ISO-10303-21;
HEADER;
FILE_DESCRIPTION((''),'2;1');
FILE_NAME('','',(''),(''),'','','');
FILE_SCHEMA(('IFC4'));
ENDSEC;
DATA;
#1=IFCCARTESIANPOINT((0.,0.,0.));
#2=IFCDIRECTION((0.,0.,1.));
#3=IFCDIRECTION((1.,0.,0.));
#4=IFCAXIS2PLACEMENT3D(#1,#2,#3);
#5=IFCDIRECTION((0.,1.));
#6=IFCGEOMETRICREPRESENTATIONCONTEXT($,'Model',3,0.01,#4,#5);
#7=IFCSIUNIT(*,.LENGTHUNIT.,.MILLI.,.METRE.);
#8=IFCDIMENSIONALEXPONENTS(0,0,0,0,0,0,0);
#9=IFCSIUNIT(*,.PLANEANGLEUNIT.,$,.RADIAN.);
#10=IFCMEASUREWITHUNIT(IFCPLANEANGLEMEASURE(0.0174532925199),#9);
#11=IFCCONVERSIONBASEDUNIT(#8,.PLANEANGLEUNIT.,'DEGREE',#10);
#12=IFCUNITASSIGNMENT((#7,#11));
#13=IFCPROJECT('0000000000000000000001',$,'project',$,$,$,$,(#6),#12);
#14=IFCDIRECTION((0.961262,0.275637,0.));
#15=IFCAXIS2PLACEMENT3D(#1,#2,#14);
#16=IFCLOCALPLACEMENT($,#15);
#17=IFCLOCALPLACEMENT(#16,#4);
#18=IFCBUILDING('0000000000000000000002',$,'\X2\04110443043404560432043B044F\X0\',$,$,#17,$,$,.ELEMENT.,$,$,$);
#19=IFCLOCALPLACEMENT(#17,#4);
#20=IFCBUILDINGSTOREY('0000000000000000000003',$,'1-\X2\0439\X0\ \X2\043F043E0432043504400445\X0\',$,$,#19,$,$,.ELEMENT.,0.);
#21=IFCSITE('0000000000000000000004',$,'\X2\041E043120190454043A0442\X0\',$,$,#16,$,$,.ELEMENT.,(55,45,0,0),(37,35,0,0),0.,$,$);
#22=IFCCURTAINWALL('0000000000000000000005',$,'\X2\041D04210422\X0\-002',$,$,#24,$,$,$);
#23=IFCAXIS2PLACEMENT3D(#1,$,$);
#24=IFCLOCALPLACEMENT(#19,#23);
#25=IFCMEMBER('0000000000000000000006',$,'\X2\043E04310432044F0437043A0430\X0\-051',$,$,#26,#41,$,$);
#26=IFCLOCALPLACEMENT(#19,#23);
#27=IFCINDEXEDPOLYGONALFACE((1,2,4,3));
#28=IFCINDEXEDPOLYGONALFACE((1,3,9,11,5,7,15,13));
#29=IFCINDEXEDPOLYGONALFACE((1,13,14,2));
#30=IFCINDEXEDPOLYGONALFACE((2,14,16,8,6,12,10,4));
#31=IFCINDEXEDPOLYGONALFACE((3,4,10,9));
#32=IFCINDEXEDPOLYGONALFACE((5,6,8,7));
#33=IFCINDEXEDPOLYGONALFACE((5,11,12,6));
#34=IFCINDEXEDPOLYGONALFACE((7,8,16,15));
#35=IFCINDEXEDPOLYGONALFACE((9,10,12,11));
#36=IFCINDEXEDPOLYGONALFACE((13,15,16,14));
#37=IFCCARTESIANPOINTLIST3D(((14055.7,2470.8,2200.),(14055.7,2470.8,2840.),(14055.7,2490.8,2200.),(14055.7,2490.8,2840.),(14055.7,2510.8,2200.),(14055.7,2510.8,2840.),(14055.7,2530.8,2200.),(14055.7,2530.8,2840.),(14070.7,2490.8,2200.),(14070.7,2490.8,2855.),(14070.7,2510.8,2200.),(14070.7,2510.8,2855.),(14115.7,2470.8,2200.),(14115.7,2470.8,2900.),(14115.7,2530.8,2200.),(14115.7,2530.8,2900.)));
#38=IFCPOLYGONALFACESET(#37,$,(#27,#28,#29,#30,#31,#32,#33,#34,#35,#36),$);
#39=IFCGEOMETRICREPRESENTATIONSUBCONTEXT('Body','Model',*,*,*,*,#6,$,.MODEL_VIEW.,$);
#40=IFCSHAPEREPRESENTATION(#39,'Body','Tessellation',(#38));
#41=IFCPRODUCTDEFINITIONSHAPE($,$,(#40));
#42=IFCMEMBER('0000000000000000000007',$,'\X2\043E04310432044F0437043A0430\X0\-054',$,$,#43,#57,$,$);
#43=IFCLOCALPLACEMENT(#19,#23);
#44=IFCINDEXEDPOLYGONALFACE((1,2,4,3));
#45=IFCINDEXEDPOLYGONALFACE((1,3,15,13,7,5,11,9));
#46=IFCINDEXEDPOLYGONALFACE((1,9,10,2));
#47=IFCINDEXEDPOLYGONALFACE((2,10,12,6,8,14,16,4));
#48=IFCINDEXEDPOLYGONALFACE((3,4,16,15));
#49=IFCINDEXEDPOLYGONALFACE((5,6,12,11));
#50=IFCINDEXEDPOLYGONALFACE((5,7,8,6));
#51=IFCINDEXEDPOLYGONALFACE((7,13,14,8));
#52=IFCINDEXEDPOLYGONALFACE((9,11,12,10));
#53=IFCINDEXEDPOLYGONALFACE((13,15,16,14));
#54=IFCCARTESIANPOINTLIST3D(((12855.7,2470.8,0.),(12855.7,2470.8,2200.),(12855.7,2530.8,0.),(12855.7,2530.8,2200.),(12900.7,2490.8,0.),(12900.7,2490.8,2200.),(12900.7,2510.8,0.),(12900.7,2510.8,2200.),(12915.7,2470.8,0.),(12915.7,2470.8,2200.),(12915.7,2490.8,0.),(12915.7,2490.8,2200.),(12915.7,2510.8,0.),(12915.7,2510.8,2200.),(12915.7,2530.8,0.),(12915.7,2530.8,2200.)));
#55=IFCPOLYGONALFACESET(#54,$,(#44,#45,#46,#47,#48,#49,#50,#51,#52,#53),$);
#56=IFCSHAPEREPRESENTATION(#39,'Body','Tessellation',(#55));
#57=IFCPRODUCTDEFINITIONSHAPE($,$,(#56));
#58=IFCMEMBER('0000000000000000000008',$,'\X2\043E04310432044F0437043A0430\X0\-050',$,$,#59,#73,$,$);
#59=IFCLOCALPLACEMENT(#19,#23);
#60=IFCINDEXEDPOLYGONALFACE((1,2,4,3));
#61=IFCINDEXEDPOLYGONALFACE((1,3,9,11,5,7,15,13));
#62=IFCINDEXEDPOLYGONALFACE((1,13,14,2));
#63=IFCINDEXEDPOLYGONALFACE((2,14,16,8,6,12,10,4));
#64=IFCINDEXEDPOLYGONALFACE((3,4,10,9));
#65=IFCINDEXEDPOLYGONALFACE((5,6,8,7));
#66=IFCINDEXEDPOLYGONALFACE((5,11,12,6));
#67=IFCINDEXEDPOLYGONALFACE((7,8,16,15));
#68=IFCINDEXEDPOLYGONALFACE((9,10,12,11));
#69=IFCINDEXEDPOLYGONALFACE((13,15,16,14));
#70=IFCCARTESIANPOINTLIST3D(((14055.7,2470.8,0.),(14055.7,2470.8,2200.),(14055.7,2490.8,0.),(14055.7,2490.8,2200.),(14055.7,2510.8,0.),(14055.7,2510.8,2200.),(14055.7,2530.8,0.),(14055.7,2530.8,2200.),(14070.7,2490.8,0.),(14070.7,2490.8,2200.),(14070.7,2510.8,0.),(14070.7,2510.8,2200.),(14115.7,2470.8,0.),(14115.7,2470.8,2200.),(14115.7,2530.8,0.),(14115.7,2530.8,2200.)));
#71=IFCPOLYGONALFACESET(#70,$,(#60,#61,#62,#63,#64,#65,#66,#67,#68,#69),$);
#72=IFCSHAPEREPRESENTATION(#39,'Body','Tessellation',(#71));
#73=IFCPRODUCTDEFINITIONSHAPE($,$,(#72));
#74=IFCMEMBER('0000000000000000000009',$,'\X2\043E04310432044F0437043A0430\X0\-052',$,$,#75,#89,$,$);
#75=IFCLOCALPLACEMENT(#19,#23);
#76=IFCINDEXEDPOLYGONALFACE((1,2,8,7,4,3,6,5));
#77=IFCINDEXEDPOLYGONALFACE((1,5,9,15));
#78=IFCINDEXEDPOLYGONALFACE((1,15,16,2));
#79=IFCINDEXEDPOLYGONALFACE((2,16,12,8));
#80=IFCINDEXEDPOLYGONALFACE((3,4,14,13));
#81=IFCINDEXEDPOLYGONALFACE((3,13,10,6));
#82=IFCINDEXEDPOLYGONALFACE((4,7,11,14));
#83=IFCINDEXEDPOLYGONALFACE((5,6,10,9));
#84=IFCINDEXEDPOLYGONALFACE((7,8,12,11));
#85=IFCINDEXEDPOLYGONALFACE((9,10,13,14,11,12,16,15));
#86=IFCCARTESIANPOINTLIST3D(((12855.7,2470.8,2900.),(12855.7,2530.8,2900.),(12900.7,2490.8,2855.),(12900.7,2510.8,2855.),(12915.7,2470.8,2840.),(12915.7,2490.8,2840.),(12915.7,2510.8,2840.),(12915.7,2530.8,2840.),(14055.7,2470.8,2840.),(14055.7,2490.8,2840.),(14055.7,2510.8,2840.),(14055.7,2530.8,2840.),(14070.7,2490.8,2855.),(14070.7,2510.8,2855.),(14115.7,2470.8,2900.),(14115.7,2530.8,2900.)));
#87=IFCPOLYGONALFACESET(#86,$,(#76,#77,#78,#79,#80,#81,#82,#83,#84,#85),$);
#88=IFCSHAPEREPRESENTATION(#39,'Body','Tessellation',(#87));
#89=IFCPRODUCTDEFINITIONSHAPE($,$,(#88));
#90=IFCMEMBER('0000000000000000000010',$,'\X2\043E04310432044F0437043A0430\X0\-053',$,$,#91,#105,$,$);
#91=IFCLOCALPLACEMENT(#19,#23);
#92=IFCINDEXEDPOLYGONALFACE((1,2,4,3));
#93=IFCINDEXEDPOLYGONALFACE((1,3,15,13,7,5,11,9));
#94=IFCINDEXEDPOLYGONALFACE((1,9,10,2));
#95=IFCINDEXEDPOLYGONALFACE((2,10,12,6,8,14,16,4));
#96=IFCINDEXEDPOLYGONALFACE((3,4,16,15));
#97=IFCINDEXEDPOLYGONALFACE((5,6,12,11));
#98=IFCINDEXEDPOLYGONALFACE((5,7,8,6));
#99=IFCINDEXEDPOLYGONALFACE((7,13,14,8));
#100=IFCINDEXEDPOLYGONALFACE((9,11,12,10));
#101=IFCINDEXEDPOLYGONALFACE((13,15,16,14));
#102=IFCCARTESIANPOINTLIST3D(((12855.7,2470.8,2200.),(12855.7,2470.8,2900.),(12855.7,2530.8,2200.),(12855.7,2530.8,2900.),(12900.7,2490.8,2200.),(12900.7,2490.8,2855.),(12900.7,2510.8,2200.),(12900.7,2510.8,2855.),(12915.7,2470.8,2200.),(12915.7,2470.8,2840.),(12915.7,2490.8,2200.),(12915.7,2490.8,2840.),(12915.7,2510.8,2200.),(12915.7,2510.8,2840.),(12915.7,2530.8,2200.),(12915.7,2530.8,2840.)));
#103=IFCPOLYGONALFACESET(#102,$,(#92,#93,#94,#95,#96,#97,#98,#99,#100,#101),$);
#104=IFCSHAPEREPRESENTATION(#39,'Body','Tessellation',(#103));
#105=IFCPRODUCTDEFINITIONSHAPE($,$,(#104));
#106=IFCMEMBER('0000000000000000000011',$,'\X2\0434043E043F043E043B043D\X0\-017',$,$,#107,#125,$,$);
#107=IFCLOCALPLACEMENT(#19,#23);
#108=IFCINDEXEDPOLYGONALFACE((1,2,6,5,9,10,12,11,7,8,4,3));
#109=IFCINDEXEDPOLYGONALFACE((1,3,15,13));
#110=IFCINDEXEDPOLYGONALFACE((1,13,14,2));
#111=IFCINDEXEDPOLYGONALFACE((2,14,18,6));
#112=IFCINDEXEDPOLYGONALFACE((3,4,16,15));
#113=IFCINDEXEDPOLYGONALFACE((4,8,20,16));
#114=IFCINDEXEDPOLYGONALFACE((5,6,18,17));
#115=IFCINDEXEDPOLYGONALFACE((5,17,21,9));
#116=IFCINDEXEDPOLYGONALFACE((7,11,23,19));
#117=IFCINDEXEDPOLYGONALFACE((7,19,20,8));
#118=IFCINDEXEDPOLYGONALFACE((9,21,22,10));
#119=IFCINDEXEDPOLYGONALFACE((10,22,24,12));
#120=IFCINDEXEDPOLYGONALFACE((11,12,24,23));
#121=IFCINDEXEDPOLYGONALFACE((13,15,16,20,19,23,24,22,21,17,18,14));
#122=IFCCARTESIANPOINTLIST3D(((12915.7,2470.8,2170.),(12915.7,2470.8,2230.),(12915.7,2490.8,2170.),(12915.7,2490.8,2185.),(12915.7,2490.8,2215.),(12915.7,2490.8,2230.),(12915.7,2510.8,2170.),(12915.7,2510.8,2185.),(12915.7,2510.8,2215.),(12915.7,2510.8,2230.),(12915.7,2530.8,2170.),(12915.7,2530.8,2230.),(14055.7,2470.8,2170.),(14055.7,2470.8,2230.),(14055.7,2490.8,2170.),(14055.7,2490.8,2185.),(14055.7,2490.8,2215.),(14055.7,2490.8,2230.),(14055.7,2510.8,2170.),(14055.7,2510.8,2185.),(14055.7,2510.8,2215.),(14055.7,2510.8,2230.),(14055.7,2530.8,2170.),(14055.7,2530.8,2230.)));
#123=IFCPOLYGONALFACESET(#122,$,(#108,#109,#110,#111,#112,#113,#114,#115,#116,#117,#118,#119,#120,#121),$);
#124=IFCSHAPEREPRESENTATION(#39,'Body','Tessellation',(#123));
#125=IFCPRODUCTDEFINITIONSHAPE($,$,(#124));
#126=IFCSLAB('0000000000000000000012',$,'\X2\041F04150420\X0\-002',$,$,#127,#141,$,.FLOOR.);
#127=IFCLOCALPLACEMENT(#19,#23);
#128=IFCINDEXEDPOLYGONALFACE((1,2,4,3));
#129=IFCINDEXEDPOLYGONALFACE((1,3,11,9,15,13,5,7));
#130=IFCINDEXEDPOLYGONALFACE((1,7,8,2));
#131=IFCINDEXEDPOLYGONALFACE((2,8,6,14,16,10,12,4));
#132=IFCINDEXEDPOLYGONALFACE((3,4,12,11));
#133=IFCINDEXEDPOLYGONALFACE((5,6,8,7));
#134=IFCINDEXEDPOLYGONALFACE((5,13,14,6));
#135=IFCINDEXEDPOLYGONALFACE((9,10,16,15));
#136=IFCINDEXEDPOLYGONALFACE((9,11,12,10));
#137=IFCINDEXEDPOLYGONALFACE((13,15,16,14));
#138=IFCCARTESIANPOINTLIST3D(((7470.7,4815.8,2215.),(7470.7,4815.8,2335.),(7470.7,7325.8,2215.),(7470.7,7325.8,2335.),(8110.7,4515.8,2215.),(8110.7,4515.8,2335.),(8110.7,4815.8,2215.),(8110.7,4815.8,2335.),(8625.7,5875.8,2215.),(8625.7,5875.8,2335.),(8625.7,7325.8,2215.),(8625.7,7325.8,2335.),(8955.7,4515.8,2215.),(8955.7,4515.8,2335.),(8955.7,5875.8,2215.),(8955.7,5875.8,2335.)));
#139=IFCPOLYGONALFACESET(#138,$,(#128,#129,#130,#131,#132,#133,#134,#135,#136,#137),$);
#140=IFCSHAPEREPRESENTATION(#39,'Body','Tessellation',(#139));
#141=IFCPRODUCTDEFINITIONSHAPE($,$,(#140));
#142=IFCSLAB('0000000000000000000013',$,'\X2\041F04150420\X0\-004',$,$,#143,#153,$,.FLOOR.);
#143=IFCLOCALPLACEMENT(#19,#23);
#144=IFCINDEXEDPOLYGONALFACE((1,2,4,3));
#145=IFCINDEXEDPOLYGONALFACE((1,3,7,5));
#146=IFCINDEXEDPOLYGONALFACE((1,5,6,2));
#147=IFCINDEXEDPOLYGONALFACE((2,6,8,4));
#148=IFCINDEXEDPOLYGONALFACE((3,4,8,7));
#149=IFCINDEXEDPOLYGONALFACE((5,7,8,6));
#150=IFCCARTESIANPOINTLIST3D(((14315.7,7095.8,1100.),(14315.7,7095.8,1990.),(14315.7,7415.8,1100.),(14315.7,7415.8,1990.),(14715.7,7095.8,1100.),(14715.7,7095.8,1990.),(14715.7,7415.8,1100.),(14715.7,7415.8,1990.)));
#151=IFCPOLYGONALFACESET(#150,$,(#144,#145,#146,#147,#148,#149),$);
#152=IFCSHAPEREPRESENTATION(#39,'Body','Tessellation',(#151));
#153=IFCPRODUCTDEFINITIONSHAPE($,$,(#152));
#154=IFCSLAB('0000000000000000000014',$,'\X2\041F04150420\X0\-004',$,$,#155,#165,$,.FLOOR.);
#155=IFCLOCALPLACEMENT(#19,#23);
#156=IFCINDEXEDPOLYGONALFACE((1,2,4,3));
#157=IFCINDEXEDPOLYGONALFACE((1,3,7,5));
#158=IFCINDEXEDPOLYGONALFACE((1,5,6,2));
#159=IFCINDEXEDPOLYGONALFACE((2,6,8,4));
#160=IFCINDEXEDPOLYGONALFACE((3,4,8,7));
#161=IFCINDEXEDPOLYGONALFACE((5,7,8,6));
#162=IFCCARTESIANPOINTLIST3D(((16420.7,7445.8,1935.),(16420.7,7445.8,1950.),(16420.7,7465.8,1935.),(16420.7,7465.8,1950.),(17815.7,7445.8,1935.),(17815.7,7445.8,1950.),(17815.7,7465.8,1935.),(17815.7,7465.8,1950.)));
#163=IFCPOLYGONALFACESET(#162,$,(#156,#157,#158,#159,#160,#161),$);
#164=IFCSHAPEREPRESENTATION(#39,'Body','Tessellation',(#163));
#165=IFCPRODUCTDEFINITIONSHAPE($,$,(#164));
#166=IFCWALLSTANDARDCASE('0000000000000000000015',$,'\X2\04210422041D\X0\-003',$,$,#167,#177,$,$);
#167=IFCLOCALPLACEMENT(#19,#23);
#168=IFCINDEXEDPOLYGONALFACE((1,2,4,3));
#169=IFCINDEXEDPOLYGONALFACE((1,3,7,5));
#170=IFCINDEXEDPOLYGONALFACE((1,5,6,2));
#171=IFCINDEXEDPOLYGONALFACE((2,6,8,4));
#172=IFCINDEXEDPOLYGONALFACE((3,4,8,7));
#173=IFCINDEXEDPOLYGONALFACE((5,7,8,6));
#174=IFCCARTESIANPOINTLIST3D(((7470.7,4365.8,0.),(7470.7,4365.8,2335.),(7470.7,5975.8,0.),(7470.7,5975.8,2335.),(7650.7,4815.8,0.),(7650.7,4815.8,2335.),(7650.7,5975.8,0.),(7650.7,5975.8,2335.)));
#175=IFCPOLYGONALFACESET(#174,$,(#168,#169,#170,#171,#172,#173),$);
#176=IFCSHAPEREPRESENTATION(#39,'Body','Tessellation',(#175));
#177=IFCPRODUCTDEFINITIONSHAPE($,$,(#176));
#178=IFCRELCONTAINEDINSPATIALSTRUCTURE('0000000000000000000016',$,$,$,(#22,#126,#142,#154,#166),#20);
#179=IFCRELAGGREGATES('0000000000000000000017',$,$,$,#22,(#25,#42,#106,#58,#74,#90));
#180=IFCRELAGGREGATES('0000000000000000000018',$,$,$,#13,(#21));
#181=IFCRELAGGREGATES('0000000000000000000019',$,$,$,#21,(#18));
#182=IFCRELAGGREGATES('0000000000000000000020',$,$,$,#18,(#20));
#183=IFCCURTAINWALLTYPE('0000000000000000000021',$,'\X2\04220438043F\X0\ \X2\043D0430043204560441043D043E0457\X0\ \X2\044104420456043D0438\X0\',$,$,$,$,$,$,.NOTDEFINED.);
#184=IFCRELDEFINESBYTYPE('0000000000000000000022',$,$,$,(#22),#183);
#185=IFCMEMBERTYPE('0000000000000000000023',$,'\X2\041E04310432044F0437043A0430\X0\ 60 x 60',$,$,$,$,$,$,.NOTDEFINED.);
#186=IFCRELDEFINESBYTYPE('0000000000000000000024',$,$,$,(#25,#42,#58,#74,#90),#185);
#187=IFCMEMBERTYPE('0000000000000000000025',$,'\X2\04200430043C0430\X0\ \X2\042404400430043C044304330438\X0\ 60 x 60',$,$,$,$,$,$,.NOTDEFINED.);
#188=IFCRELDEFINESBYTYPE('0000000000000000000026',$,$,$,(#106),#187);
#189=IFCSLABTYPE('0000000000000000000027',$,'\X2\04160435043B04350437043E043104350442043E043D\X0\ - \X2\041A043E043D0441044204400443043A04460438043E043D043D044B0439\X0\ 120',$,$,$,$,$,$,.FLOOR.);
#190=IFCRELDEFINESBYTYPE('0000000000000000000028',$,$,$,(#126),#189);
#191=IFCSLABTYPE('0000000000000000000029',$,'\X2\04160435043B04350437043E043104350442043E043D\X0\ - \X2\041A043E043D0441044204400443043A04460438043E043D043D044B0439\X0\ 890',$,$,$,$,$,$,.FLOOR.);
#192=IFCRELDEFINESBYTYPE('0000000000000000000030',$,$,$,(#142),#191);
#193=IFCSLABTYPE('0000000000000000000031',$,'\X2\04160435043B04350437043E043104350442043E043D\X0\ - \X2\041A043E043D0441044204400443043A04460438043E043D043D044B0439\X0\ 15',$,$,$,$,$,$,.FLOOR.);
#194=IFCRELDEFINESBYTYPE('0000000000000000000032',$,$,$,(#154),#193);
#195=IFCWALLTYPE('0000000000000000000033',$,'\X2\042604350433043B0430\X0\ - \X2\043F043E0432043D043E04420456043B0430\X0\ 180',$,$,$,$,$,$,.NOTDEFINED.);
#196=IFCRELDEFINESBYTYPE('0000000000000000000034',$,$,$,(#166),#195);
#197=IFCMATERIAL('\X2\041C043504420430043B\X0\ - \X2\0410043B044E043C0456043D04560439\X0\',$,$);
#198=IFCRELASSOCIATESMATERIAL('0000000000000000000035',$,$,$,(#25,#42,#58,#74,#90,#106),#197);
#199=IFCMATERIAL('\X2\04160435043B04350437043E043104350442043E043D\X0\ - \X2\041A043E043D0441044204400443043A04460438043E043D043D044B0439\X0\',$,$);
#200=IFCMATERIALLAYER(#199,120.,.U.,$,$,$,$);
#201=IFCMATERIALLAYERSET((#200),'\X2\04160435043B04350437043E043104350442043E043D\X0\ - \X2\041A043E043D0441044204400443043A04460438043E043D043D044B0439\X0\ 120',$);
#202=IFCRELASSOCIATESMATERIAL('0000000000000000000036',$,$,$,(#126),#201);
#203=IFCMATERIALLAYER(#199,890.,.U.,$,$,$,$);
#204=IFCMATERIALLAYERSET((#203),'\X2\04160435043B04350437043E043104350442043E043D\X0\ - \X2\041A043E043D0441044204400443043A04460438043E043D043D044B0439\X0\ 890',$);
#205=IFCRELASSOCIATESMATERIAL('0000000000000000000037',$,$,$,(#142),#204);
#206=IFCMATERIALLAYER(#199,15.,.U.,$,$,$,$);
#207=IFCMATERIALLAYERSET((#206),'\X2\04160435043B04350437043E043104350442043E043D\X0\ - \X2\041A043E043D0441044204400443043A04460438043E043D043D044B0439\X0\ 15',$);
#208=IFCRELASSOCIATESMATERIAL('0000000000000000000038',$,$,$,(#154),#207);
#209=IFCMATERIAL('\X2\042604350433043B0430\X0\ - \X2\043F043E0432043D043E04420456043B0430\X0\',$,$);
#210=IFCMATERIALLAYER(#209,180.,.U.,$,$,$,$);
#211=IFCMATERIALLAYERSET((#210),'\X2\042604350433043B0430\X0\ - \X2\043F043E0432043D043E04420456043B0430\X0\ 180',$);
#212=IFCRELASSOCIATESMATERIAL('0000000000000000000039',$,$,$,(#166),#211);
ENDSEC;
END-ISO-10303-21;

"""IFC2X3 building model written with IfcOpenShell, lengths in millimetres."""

from ifc_helpers import new_model, entity, si_unit, converted_unit, direction, frame, origin_with_axes, place, context, subcontext, project, spatial, polyline, outline, extrude, clip, halfspace, material, layer, layer_set, layer_usage, type_object, element, aggregate, save


model = new_model("IFC2X3")

# Units and contexts
model_context = context("Model", 3, precision=0.01, world=origin_with_axes(), true_north=direction((0.0, 1.0)))
body_context = subcontext(model_context, "Body", "Model", "MODEL_VIEW")
ifc_project = project(units=[si_unit("LENGTHUNIT", "METRE", prefix="MILLI"), converted_unit("PLANEANGLEUNIT", "DEGREE", entity("IfcPlaneAngleMeasure", 0.0174532925199), si_unit("PLANEANGLEUNIT", "RADIAN"), dimensions=[0, 0, 0, 0, 0, 0, 0])], contexts=[model_context])

# Site, building, storey
site_placement = place(None, frame((0.0, 0.0, 0.0), z_axis=(0.0, 0.0, 1.0), x_axis=(0.961262, 0.275637, 0.0)))
site = spatial("IfcSite", under=ifc_project, at=site_placement, Name="Об’єкт", CompositionType="ELEMENT", RefLatitude=(55, 45, 0, 0), RefLongitude=(37, 35, 0, 0), RefElevation=0.0)
building_placement = place(site_placement, origin_with_axes())
building = spatial("IfcBuilding", under=site, at=building_placement, Name="Будівля", CompositionType="ELEMENT")
storey_placement = place(building_placement, origin_with_axes())
storey = spatial("IfcBuildingStorey", under=building, at=storey_placement, Name="1-й поверх", CompositionType="ELEMENT", Elevation=0.0)

# Curtain wall, members
curtain_wall_type = type_object("IfcCurtainWallType", Name="Тип навісної стіни", PredefinedType="NOTDEFINED")
curtain_wall_placement = place(storey_placement, frame((13485.7, 2500.8, 0.0), z_axis=(0.0, 0.0, 1.0), x_axis=(1.0, 0.0, 0.0)))
curtain_wall = element("IfcCurtainWall", 1, at=curtain_wall_placement, inside=storey, type_object=curtain_wall_type, Name="НСТ-002")
ifc_material_1 = material(Name="Метал - Алюміній")
member_type_1 = type_object("IfcMemberType", Name="Обвязка 60 x 60", PredefinedType="NOTDEFINED")
member_1_placement = place(curtain_wall_placement, frame((630.0, 0.0, 2200.0), z_axis=(0.0, 0.0, 1.0), x_axis=(-1.0, 0.0, 0.0)))
member_1 = element("IfcMember", 2, at=member_1_placement, type_object=member_type_1, material=ifc_material_1, Name="обвязка-051", context=body_context, shape_type="Clipping", body=[
    clip(extrude(outline(polyline([(-45.0, 10.0), (-45.0, -10.0), (-60.0, -10.0), (-60.0, -30.0), (0.0, -30.0), (0.0, 30.0), (-60.0, 30.0), (-60.0, 10.0), (-45.0, 10.0)])), frame((0.0, 0.0, 0.0), z_axis=(0.0, 0.0, 1.0), x_axis=(-1.0, 0.0, 0.0)), (0.0, 0.0, 1.0), 700.0), halfspace(frame((350.0, 0.0, 350.0), z_axis=(-0.707107, 0.0, -0.707107), x_axis=(0.0, 1.0, 0.0)), True)),
])
member_2_placement = place(curtain_wall_placement, frame((-630.0, 0.0, 0.0), z_axis=(0.0, 0.0, 1.0), x_axis=(-1.0, 0.0, 0.0)))
member_2 = element("IfcMember", 3, at=member_2_placement, type_object=member_type_1, material=ifc_material_1, Name="обвязка-054", context=body_context, shape_type="SweptSolid", body=[
    extrude(outline(polyline([(45.0, 10.0), (60.0, 10.0), (60.0, 30.0), (0.0, 30.0), (0.0, -30.0), (60.0, -30.0), (60.0, -10.0), (45.0, -10.0), (45.0, 10.0)])), frame((0.0, 0.0, 0.0), z_axis=(0.0, 0.0, 1.0), x_axis=(-1.0, 0.0, 0.0)), (0.0, 0.0, 1.0), 2200.0),
])
member_3_placement = place(curtain_wall_placement, frame((630.0, 0.0, 0.0), z_axis=(0.0, 0.0, 1.0), x_axis=(-1.0, 0.0, 0.0)))
member_3 = element("IfcMember", 4, at=member_3_placement, type_object=member_type_1, material=ifc_material_1, Name="обвязка-050", context=body_context, shape_type="SweptSolid", body=[
    extrude(outline(polyline([(-45.0, 10.0), (-45.0, -10.0), (-60.0, -10.0), (-60.0, -30.0), (0.0, -30.0), (0.0, 30.0), (-60.0, 30.0), (-60.0, 10.0), (-45.0, 10.0)])), frame((0.0, 0.0, 0.0), z_axis=(0.0, 0.0, 1.0), x_axis=(-1.0, 0.0, 0.0)), (0.0, 0.0, 1.0), 2200.0),
])
member_4_placement = place(curtain_wall_placement, frame((-630.0, 0.0, 2900.0), z_axis=(1.0, 0.0, 0.0), x_axis=(0.0, 0.0, 1.0)))
member_4 = element("IfcMember", 5, at=member_4_placement, type_object=member_type_1, material=ifc_material_1, Name="обвязка-052", context=body_context, shape_type="Clipping", body=[
    clip(clip(extrude(outline(polyline([(-10.0, 45.0), (-10.0, 60.0), (-30.0, 60.0), (-30.0, 0.0), (30.0, 0.0), (30.0, 60.0), (10.0, 60.0), (10.0, 45.0), (-10.0, 45.0)])), frame((0.0, 0.0, 0.0), z_axis=(0.0, 0.0, 1.0), x_axis=(0.0, 1.0, 0.0)), (0.0, 0.0, 1.0), 1260.0), halfspace(frame((-630.0, 0.0, 630.0), z_axis=(0.707107, 0.0, -0.707107), x_axis=(0.0, 1.0, 0.0)), True)), halfspace(frame((0.0, 0.0, 0.0), z_axis=(0.707107, 0.0, 0.707107), x_axis=(0.0, -1.0, 0.0)), True)),
])
member_5_placement = place(curtain_wall_placement, frame((-630.0, 0.0, 2200.0), z_axis=(0.0, 0.0, 1.0), x_axis=(-1.0, 0.0, 0.0)))
member_5 = element("IfcMember", 6, at=member_5_placement, type_object=member_type_1, material=ifc_material_1, Name="обвязка-053", context=body_context, shape_type="Clipping", body=[
    clip(extrude(outline(polyline([(45.0, 10.0), (60.0, 10.0), (60.0, 30.0), (0.0, 30.0), (0.0, -30.0), (60.0, -30.0), (60.0, -10.0), (45.0, -10.0), (45.0, 10.0)])), frame((0.0, 0.0, 0.0), z_axis=(0.0, 0.0, 1.0), x_axis=(-1.0, 0.0, 0.0)), (0.0, 0.0, 1.0), 700.0), halfspace(frame((-350.0, 0.0, 350.0), z_axis=(0.707107, 0.0, -0.707107), x_axis=(0.0, 1.0, 0.0)), True)),
])
member_type_2 = type_object("IfcMemberType", Name="Рама Фрамуги 60 x 60", PredefinedType="NOTDEFINED")
member_6_placement = place(curtain_wall_placement, frame((-630.0, 0.0, 2200.0), z_axis=(1.0, 0.0, 0.0), x_axis=(0.0, 0.0, 1.0)))
member_6 = element("IfcMember", 7, at=member_6_placement, type_object=member_type_2, material=ifc_material_1, Name="дополн-017", context=body_context, shape_type="SweptSolid", body=[
    extrude(outline(polyline([(-10.0, 15.0), (-10.0, 30.0), (-30.0, 30.0), (-30.0, -30.0), (-10.0, -30.0), (-10.0, -15.0), (10.0, -15.0), (10.0, -30.0), (30.0, -30.0), (30.0, 30.0), (10.0, 30.0), (10.0, 15.0), (-10.0, 15.0)])), frame((0.0, 0.0, 60.0), z_axis=(0.0, 0.0, 1.0), x_axis=(0.0, 1.0, 0.0)), (0.0, 0.0, 1.0), 1140.0),
])

# Slab
ifc_material_2 = material(Name="Железобетон - Конструкционный")
ifc_layer_1 = layer(ifc_material_2, 120.0, ventilated="UNKNOWN")
ifc_layer_set_1 = layer_set([ifc_layer_1], Name="Железобетон - Конструкционный 120")
ifc_layer_usage_1 = layer_usage(ifc_layer_set_1, "AXIS3", "NEGATIVE", 120.0)
slab_type_1 = type_object("IfcSlabType", Name="Железобетон - Конструкционный 120", PredefinedType="FLOOR")
slab_1_placement = place(storey_placement, frame((7470.7, 4815.8, 2335.0), z_axis=(0.0, 0.0, 1.0), x_axis=(1.0, 0.0, 0.0)))
element("IfcSlab", 8, at=slab_1_placement, inside=storey, type_object=slab_type_1, material=ifc_layer_usage_1, Name="ПЕР-002", PredefinedType="FLOOR", context=body_context, shape_type="SweptSolid", body=[
    extrude(outline(polyline([(0.0, 0.0), (640.0, 0.0), (640.0, -300.0), (1485.0, -300.0), (1485.0, 1060.0), (1155.0, 1060.0), (1155.0, 2510.0), (0.0, 2510.0), (0.0, 0.0)])), frame((0.0, 0.0, -120.0), z_axis=(0.0, 0.0, 1.0), x_axis=(1.0, 0.0, 0.0)), (0.0, 0.0, 1.0), 120.0),
])

aggregate(curtain_wall, [member_1, member_2, member_6, member_3, member_4, member_5])

# Slabs
ifc_layer_2 = layer(ifc_material_2, 890.0, ventilated="UNKNOWN")
ifc_layer_set_2 = layer_set([ifc_layer_2], Name="Железобетон - Конструкционный 890")
ifc_layer_usage_2 = layer_usage(ifc_layer_set_2, "AXIS3", "NEGATIVE", 890.0)
slab_type_2 = type_object("IfcSlabType", Name="Железобетон - Конструкционный 890", PredefinedType="FLOOR")
slab_2_placement = place(storey_placement, frame((14715.7, 7095.8, 1990.0), z_axis=(0.0, 0.0, 1.0), x_axis=(1.0, 0.0, 0.0)))
element("IfcSlab", 9, at=slab_2_placement, inside=storey, type_object=slab_type_2, material=ifc_layer_usage_2, Name="ПЕР-004", PredefinedType="FLOOR", context=body_context, shape_type="SweptSolid", body=[
    extrude(outline(polyline([(0.0, 0.0), (0.0, 320.0), (-400.0, 320.0), (-400.0, 0.0), (0.0, 0.0)])), frame((0.0, 0.0, -890.0), z_axis=(0.0, 0.0, 1.0), x_axis=(1.0, 0.0, 0.0)), (0.0, 0.0, 1.0), 890.0),
])
ifc_layer_3 = layer(ifc_material_2, 15.0, ventilated="UNKNOWN")
ifc_layer_set_3 = layer_set([ifc_layer_3], Name="Железобетон - Конструкционный 15")
ifc_layer_usage_3 = layer_usage(ifc_layer_set_3, "AXIS3", "NEGATIVE", 15.0)
slab_type_3 = type_object("IfcSlabType", Name="Железобетон - Конструкционный 15", PredefinedType="FLOOR")
slab_3_placement = place(storey_placement, frame((16420.7, 7465.8, 1950.0), z_axis=(0.0, 0.0, 1.0), x_axis=(1.0, 0.0, 0.0)))
element("IfcSlab", 10, at=slab_3_placement, inside=storey, type_object=slab_type_3, material=ifc_layer_usage_3, Name="ПЕР-004", PredefinedType="FLOOR", context=body_context, shape_type="SweptSolid", body=[
    extrude(outline(polyline([(0.0, 0.0), (0.0, -20.0), (1395.0, -20.0), (1395.0, 0.0), (0.0, 0.0)])), frame((0.0, 0.0, -15.0), z_axis=(0.0, 0.0, 1.0), x_axis=(1.0, 0.0, 0.0)), (0.0, 0.0, 1.0), 15.0),
])

# Wall
ifc_material_3 = material(Name="Цегла - повнотіла")
ifc_layer_4 = layer(ifc_material_3, 180.0, ventilated="UNKNOWN")
ifc_layer_set_4 = layer_set([ifc_layer_4], Name="Цегла - повнотіла 180")
ifc_layer_usage_4 = layer_usage(ifc_layer_set_4, "AXIS2", "POSITIVE", 0.0)
wall_type_1 = type_object("IfcWallType", Name="Цегла - повнотіла 180", PredefinedType="NOTDEFINED")
wall_1_placement = place(storey_placement, frame((7470.7, 5975.8, 0.0), z_axis=(0.0, 0.0, 1.0), x_axis=(0.0, -1.0, 0.0)))
element("IfcWallStandardCase", 11, at=wall_1_placement, inside=storey, type_object=wall_type_1, material=ifc_layer_usage_4, Name="СТН-003", context=body_context, shape_type="SweptSolid", body=[
    extrude(outline(polyline([(0.0, 0.0), (1610.0, 0.0), (1160.0, 180.0), (0.0, 180.0), (0.0, 0.0)])), origin_with_axes(), (0.0, 0.0, 1.0), 2335.0),
])

save(model, "model.ifc")
